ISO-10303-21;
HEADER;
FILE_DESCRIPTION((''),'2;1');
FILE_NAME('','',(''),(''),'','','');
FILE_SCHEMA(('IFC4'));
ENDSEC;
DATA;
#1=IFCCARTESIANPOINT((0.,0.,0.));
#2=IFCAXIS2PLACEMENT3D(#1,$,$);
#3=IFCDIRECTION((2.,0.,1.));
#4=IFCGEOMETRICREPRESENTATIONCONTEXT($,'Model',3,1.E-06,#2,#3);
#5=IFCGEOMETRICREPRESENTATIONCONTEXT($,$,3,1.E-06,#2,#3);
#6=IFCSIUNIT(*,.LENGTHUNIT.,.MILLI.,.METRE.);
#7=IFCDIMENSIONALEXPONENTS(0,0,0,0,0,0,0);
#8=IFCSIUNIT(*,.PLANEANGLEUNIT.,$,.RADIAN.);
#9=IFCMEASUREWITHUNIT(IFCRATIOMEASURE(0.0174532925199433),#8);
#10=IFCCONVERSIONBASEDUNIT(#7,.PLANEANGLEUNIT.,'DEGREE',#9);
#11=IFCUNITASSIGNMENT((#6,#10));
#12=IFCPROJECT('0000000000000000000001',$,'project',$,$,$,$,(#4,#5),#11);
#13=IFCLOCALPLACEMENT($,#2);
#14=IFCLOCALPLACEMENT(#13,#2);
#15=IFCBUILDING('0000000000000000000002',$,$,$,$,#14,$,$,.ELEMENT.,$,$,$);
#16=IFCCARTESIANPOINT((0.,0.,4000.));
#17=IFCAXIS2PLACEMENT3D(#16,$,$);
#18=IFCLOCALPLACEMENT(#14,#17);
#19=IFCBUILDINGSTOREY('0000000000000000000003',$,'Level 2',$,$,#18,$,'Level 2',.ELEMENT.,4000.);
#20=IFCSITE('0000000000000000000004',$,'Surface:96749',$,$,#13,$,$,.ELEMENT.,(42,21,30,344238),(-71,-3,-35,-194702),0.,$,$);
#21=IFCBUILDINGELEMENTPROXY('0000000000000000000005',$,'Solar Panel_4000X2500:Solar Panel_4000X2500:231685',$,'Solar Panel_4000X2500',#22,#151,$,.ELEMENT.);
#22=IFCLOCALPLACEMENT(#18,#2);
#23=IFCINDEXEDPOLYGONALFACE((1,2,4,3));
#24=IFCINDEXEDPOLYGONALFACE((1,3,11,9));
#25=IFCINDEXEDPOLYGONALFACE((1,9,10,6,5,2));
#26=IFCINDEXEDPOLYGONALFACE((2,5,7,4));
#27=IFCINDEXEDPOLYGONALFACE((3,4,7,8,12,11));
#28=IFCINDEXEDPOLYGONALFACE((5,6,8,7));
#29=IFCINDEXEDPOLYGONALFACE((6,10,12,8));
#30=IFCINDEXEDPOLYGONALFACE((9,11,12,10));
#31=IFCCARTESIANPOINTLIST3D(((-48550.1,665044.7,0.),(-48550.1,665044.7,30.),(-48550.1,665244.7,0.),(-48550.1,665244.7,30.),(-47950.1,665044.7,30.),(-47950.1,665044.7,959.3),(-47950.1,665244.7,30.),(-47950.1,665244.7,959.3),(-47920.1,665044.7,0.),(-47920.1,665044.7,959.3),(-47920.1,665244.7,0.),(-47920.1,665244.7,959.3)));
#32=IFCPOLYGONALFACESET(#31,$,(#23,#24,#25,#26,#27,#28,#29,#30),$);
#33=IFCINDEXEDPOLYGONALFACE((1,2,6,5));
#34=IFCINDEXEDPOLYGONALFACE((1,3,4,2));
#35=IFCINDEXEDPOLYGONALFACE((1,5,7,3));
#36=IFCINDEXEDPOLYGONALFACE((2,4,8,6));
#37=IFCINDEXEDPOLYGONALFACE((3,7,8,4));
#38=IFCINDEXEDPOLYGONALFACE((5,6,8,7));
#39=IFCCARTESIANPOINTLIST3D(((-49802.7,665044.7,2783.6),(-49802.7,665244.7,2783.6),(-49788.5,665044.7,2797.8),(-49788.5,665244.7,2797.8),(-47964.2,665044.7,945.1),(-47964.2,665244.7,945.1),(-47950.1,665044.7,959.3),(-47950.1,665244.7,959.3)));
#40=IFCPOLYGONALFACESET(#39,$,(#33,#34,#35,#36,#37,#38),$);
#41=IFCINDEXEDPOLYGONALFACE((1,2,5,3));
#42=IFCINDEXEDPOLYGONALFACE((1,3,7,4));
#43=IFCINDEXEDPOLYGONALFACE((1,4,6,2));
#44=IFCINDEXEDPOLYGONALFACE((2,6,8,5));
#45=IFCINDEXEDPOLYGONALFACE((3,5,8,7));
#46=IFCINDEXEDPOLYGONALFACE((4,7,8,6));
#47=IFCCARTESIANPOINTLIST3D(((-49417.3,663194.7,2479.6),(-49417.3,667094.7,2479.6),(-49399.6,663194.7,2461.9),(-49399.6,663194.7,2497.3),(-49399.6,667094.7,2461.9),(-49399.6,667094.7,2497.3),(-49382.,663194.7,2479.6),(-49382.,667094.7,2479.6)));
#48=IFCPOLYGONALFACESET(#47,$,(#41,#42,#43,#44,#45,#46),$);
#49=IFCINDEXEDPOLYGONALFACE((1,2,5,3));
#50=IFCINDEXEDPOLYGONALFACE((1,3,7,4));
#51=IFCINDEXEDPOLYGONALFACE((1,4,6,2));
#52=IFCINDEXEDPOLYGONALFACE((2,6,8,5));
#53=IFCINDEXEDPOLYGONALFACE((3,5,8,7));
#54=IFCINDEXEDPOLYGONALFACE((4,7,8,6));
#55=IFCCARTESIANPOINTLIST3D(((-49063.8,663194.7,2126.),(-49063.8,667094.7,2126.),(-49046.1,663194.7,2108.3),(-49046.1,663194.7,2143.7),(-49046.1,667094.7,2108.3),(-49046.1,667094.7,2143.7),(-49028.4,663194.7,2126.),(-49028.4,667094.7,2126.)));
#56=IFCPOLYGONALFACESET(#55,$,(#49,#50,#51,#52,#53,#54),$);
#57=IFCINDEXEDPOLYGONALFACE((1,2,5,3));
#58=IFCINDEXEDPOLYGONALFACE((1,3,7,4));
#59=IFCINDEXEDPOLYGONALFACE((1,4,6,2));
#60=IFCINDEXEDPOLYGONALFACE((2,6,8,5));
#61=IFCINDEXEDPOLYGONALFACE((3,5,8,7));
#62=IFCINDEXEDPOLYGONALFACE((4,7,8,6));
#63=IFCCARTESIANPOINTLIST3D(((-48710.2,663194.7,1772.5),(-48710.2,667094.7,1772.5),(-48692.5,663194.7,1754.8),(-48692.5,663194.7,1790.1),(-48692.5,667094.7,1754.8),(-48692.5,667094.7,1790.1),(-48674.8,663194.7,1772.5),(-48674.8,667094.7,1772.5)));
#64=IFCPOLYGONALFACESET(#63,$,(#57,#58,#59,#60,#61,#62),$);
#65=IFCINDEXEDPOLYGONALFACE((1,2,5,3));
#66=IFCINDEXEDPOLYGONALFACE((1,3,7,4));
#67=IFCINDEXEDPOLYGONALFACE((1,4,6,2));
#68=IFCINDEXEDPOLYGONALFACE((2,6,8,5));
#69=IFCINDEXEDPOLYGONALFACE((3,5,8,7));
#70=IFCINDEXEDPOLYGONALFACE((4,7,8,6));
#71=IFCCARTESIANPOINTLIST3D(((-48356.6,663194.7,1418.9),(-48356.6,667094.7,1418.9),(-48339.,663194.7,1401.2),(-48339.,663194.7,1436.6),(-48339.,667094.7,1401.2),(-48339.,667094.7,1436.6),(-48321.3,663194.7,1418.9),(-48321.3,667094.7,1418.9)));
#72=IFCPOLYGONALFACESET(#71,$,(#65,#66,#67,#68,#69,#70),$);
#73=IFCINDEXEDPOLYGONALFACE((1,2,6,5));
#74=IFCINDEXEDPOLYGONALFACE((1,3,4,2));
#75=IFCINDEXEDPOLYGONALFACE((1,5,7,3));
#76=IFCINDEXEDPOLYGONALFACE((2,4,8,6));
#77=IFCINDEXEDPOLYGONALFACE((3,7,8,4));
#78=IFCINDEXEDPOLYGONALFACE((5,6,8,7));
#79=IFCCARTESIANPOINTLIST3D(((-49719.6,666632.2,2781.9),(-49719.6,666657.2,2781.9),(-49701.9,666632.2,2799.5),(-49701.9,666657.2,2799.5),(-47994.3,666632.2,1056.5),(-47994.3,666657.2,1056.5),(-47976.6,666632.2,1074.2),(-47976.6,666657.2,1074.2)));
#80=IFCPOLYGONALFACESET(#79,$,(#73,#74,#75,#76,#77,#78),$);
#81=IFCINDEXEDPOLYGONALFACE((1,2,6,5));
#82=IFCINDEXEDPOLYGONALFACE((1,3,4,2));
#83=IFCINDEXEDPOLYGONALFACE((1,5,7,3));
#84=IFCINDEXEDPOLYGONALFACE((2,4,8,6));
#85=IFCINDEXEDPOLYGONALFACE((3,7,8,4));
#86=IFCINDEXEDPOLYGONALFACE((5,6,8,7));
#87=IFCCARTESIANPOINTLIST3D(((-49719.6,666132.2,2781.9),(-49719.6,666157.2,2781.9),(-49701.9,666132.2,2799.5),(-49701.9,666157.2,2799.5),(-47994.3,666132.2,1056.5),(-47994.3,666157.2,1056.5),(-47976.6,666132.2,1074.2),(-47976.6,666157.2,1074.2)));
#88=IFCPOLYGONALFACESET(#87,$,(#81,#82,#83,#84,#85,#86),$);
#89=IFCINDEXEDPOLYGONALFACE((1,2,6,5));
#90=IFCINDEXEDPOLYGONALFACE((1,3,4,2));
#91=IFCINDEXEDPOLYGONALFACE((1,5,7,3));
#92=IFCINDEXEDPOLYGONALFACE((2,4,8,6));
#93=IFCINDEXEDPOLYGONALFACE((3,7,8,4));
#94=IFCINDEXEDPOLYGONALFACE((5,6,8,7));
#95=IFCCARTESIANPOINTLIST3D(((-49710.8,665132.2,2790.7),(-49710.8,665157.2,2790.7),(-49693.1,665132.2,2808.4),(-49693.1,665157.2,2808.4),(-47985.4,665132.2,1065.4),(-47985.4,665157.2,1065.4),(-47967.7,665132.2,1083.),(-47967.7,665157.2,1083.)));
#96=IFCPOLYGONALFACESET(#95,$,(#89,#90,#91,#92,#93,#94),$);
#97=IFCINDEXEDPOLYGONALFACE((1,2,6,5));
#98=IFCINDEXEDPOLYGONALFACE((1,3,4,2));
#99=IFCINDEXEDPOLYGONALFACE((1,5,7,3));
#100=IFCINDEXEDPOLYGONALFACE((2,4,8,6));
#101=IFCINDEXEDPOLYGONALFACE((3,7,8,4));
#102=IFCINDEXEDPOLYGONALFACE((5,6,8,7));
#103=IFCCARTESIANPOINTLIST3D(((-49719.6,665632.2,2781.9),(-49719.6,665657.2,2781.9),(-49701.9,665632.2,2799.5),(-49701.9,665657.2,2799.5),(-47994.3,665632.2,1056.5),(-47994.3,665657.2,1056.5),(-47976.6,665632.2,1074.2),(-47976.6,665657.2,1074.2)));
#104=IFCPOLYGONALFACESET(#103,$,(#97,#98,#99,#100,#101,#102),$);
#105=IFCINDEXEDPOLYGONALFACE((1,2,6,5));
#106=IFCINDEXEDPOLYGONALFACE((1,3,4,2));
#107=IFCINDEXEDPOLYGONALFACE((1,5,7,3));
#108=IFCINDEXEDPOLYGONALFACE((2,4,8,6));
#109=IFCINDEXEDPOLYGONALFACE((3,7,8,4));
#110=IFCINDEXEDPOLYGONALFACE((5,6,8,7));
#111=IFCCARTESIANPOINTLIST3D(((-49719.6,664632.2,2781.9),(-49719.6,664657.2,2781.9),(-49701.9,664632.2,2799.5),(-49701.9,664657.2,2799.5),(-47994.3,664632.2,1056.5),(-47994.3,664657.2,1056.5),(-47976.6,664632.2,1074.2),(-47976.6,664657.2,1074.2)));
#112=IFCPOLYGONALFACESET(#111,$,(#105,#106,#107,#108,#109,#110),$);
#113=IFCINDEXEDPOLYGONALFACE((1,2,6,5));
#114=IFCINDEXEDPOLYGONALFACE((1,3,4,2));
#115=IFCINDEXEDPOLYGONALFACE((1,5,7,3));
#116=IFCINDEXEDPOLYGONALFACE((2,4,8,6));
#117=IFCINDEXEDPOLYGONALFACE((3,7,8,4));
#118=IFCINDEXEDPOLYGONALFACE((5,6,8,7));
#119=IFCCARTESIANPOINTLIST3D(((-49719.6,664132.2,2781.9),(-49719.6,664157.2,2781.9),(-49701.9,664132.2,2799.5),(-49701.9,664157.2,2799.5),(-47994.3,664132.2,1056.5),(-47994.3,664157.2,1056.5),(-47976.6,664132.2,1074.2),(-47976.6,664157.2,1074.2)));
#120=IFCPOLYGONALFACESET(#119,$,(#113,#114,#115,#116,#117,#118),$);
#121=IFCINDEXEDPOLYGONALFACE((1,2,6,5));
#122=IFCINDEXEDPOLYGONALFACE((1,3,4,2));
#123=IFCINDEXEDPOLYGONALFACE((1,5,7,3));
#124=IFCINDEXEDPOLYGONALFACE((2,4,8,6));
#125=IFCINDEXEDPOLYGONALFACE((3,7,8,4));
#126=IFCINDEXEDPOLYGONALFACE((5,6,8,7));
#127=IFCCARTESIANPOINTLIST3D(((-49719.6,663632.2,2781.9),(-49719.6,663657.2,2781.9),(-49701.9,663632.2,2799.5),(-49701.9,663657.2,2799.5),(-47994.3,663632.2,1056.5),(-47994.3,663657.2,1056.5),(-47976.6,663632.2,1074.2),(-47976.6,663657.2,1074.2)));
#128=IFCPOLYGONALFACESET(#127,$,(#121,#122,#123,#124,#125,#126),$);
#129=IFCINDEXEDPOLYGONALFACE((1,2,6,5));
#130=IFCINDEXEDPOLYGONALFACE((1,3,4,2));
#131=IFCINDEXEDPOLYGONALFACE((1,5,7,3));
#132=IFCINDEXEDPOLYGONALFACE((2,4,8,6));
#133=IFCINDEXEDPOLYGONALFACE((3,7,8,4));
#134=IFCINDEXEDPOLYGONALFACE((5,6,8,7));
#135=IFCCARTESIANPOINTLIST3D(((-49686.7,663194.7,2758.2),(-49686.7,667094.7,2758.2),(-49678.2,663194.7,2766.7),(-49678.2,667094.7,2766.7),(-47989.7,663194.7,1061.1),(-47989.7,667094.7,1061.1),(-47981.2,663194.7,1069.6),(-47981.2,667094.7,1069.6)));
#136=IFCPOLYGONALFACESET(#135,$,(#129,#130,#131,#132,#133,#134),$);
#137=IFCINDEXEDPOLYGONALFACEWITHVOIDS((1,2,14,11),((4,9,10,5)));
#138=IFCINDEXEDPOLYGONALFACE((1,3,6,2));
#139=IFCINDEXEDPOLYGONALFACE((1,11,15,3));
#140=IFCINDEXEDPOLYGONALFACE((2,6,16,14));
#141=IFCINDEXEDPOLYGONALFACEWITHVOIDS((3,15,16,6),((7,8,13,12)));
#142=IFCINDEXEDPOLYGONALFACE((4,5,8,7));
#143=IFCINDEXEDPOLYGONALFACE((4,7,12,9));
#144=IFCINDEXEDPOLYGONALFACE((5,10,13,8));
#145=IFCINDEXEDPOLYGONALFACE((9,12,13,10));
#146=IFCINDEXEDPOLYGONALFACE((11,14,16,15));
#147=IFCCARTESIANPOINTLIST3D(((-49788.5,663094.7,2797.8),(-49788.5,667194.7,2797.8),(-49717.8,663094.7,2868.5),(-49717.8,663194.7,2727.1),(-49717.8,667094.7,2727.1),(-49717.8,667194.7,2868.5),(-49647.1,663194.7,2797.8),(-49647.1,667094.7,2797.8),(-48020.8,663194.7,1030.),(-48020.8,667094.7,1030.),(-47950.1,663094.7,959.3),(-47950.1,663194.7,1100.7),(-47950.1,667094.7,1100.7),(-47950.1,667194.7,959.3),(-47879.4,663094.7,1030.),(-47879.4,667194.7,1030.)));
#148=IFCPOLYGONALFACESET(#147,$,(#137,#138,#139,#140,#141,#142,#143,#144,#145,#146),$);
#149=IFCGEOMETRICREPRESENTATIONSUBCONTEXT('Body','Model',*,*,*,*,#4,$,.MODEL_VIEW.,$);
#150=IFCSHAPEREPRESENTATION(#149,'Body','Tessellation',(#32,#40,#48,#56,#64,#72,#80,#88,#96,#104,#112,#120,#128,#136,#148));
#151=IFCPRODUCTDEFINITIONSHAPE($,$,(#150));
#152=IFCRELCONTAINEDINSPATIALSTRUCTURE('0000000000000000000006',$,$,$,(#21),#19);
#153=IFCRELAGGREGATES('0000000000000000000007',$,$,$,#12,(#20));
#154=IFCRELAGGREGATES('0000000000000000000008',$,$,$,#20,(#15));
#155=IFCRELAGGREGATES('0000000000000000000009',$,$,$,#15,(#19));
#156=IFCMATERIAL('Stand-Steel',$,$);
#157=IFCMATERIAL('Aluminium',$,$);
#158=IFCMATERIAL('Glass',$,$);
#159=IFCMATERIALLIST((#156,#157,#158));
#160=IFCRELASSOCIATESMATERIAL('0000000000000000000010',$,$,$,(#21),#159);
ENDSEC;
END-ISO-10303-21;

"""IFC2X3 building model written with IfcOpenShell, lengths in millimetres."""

from ifc_helpers import new_model, entity, si_unit, converted_unit, direction, frame, frame_2d, origin, origin_2d_with_axis, place, context, subcontext, project, spatial, polyline, rectangle, outline, extrude, source, transform, mapped, material, material_list, element, save


model = new_model("IFC2X3")

# Units and contexts
model_context = context("Model", 3, precision=1e-06, world=origin(), true_north=direction((2.0, 0.0, 1.0)))
context_of_model = context(None, 3, precision=1e-06, world=origin(), true_north=direction((2.0, 0.0, 1.0)))
body_context = subcontext(model_context, "Body", "Model", "MODEL_VIEW")
ifc_project = project(units=[si_unit("LENGTHUNIT", "METRE", prefix="MILLI"), converted_unit("PLANEANGLEUNIT", "DEGREE", entity("IfcRatioMeasure", 0.0174532925199433), si_unit("PLANEANGLEUNIT", "RADIAN"), dimensions=[0, 0, 0, 0, 0, 0, 0])], contexts=[model_context, context_of_model])

# Site, building, storey
site_placement = place(None, origin())
site = spatial("IfcSite", under=ifc_project, at=site_placement, Name="Surface:96749", CompositionType="ELEMENT", RefLatitude=(42, 21, 30, 344238), RefLongitude=(-71, -3, -35, -194702), RefElevation=0.0)
building_placement = place(site_placement, origin())
building = spatial("IfcBuilding", under=site, at=building_placement, CompositionType="ELEMENT")
storey_placement = place(building_placement, frame((0.0, 0.0, 4000.0)))
storey = spatial("IfcBuildingStorey", under=building, at=storey_placement, Name="Level 2", LongName="Level 2", CompositionType="ELEMENT", Elevation=4000.0)

# Building element proxy
ifc_material_1 = material(Name="Stand-Steel")
ifc_material_2 = material(Name="Aluminium")
ifc_material_3 = material(Name="Glass")
shared_shape = source(origin(), body_context, "Body", "SweptSolid", [
    extrude(outline(polyline([(-629.5, -220.0), (329.8, -220.0), (329.8, 410.0), (299.8, 410.0), (299.8, -190.0), (-629.5, -190.0), (-629.5, -220.0)])), frame((-190.0, -100.0, 299.8), z_axis=(0.0, 1.0, 0.0), x_axis=(0.0, 0.0, -1.0)), (0.0, 0.0, 1.0), 200.0),
    extrude(rectangle(XDim=20.0, YDim=200.0, at=frame_2d((0.0, 0.0), x_axis=(0.0, 1.0))), frame((-7.1, 0.0, 922.2), z_axis=(-0.707107, 0.0, 0.707107), x_axis=(0.0, 1.0, 0.0)), (0.0, 0.0, 1.0), 2600.0),
    extrude(rectangle(XDim=25.0, YDim=25.0, at=frame_2d((0.0, 0.0), x_axis=(1.0, 0.0))), frame((-1449.6, -1950.0, 2449.6), z_axis=(0.0, 1.0, 0.0), x_axis=(-0.707107, 0.0, -0.707107)), (0.0, 0.0, 1.0), 3900.0),
    extrude(rectangle(XDim=25.0, YDim=25.0, at=origin_2d_with_axis()), frame((-1096.0, -1950.0, 2096.0), z_axis=(0.0, 1.0, 0.0), x_axis=(-0.707107, 0.0, -0.707107)), (0.0, 0.0, 1.0), 3900.0),
    extrude(rectangle(XDim=25.0, YDim=25.0, at=origin_2d_with_axis()), frame((-742.5, -1950.0, 1742.5), z_axis=(0.0, 1.0, 0.0), x_axis=(-0.707107, 0.0, -0.707107)), (0.0, 0.0, 1.0), 3900.0),
    extrude(rectangle(XDim=25.0, YDim=25.0, at=frame_2d((0.0, 0.0), x_axis=(1.0, 0.0))), frame((-388.9, -1950.0, 1388.9), z_axis=(0.0, 1.0, 0.0), x_axis=(-0.707107, 0.0, -0.707107)), (0.0, 0.0, 1.0), 3900.0),
    extrude(rectangle(XDim=25.0, YDim=25.0, at=frame_2d((0.0, 0.0), x_axis=(0.0, 1.0))), frame((-35.4, 1500.0, 1035.4), z_axis=(-0.707107, 0.0, 0.707107), x_axis=(0.0, 1.0, 0.0)), (0.0, 0.0, 1.0), 2440.0),
    extrude(rectangle(XDim=25.0, YDim=25.0, at=frame_2d((0.0, 0.0), x_axis=(0.0, 1.0))), frame((-35.4, 1000.0, 1035.4), z_axis=(-0.707107, 0.0, 0.707107), x_axis=(0.0, 1.0, 0.0)), (0.0, 0.0, 1.0), 2440.0),
    extrude(rectangle(XDim=25.0, YDim=25.0, at=frame_2d((0.0, 0.0), x_axis=(0.0, 1.0))), frame((-26.5, 0.0, 1044.2), z_axis=(-0.707107, 0.0, 0.707107), x_axis=(0.0, -1.0, 0.0)), (0.0, 0.0, 1.0), 2440.0),
    extrude(rectangle(XDim=25.0, YDim=25.0, at=frame_2d((0.0, 0.0), x_axis=(0.0, 1.0))), frame((-35.4, 500.0, 1035.4), z_axis=(-0.707107, 0.0, 0.707107), x_axis=(0.0, 1.0, 0.0)), (0.0, 0.0, 1.0), 2440.0),
    extrude(rectangle(XDim=25.0, YDim=25.0, at=frame_2d((0.0, 0.0), x_axis=(0.0, 1.0))), frame((-35.4, -500.0, 1035.4), z_axis=(-0.707107, 0.0, 0.707107), x_axis=(0.0, 1.0, 0.0)), (0.0, 0.0, 1.0), 2440.0),
    extrude(rectangle(XDim=25.0, YDim=25.0, at=frame_2d((0.0, 0.0), x_axis=(0.0, 1.0))), frame((-35.4, -1000.0, 1035.4), z_axis=(-0.707107, 0.0, 0.707107), x_axis=(0.0, 1.0, 0.0)), (0.0, 0.0, 1.0), 2440.0),
    extrude(rectangle(XDim=25.0, YDim=25.0, at=frame_2d((0.0, 0.0), x_axis=(0.0, 1.0))), frame((-35.4, -1500.0, 1035.4), z_axis=(-0.707107, 0.0, 0.707107), x_axis=(0.0, 1.0, 0.0)), (0.0, 0.0, 1.0), 2440.0),
    extrude(rectangle(XDim=2400.0, YDim=12.0, at=frame_2d((0.0, 0.0), x_axis=(1.0, 0.0))), frame((-883.9, -1950.0, 1883.9), z_axis=(0.0, 1.0, 0.0), x_axis=(0.707107, 0.0, -0.707107)), (0.0, 0.0, 1.0), 3900.0),
    extrude(outline(polyline([(-2050.0, -1300.0), (2050.0, -1300.0), (2050.0, 1300.0), (-2050.0, 1300.0), (-2050.0, -1300.0)]), holes=[polyline([(1950.0, -1200.0), (-1950.0, -1200.0), (-1950.0, 1200.0), (1950.0, 1200.0), (1950.0, -1200.0)])]), frame((-919.2, 0.0, 1848.5), z_axis=(0.707107, 0.0, 0.707107), x_axis=(0.0, 1.0, 0.0)), (0.0, 0.0, 1.0), 100.0),
])
ifc_material_list_1 = material_list([ifc_material_1, ifc_material_2, ifc_material_3])
proxy_1_placement = place(storey_placement, frame((-47950.1, 665144.7, 30.0)))
element("IfcBuildingElementProxy", 1, at=proxy_1_placement, inside=storey, material=ifc_material_list_1, Name="Solar Panel_4000X2500:Solar Panel_4000X2500:231685", ObjectType="Solar Panel_4000X2500", CompositionType="ELEMENT", context=body_context, shape_type="MappedRepresentation", body=[
    mapped(shared_shape, transform((0.0, 0.0, 0.0), scale=1.0)),
])

save(model, "model.ifc")
